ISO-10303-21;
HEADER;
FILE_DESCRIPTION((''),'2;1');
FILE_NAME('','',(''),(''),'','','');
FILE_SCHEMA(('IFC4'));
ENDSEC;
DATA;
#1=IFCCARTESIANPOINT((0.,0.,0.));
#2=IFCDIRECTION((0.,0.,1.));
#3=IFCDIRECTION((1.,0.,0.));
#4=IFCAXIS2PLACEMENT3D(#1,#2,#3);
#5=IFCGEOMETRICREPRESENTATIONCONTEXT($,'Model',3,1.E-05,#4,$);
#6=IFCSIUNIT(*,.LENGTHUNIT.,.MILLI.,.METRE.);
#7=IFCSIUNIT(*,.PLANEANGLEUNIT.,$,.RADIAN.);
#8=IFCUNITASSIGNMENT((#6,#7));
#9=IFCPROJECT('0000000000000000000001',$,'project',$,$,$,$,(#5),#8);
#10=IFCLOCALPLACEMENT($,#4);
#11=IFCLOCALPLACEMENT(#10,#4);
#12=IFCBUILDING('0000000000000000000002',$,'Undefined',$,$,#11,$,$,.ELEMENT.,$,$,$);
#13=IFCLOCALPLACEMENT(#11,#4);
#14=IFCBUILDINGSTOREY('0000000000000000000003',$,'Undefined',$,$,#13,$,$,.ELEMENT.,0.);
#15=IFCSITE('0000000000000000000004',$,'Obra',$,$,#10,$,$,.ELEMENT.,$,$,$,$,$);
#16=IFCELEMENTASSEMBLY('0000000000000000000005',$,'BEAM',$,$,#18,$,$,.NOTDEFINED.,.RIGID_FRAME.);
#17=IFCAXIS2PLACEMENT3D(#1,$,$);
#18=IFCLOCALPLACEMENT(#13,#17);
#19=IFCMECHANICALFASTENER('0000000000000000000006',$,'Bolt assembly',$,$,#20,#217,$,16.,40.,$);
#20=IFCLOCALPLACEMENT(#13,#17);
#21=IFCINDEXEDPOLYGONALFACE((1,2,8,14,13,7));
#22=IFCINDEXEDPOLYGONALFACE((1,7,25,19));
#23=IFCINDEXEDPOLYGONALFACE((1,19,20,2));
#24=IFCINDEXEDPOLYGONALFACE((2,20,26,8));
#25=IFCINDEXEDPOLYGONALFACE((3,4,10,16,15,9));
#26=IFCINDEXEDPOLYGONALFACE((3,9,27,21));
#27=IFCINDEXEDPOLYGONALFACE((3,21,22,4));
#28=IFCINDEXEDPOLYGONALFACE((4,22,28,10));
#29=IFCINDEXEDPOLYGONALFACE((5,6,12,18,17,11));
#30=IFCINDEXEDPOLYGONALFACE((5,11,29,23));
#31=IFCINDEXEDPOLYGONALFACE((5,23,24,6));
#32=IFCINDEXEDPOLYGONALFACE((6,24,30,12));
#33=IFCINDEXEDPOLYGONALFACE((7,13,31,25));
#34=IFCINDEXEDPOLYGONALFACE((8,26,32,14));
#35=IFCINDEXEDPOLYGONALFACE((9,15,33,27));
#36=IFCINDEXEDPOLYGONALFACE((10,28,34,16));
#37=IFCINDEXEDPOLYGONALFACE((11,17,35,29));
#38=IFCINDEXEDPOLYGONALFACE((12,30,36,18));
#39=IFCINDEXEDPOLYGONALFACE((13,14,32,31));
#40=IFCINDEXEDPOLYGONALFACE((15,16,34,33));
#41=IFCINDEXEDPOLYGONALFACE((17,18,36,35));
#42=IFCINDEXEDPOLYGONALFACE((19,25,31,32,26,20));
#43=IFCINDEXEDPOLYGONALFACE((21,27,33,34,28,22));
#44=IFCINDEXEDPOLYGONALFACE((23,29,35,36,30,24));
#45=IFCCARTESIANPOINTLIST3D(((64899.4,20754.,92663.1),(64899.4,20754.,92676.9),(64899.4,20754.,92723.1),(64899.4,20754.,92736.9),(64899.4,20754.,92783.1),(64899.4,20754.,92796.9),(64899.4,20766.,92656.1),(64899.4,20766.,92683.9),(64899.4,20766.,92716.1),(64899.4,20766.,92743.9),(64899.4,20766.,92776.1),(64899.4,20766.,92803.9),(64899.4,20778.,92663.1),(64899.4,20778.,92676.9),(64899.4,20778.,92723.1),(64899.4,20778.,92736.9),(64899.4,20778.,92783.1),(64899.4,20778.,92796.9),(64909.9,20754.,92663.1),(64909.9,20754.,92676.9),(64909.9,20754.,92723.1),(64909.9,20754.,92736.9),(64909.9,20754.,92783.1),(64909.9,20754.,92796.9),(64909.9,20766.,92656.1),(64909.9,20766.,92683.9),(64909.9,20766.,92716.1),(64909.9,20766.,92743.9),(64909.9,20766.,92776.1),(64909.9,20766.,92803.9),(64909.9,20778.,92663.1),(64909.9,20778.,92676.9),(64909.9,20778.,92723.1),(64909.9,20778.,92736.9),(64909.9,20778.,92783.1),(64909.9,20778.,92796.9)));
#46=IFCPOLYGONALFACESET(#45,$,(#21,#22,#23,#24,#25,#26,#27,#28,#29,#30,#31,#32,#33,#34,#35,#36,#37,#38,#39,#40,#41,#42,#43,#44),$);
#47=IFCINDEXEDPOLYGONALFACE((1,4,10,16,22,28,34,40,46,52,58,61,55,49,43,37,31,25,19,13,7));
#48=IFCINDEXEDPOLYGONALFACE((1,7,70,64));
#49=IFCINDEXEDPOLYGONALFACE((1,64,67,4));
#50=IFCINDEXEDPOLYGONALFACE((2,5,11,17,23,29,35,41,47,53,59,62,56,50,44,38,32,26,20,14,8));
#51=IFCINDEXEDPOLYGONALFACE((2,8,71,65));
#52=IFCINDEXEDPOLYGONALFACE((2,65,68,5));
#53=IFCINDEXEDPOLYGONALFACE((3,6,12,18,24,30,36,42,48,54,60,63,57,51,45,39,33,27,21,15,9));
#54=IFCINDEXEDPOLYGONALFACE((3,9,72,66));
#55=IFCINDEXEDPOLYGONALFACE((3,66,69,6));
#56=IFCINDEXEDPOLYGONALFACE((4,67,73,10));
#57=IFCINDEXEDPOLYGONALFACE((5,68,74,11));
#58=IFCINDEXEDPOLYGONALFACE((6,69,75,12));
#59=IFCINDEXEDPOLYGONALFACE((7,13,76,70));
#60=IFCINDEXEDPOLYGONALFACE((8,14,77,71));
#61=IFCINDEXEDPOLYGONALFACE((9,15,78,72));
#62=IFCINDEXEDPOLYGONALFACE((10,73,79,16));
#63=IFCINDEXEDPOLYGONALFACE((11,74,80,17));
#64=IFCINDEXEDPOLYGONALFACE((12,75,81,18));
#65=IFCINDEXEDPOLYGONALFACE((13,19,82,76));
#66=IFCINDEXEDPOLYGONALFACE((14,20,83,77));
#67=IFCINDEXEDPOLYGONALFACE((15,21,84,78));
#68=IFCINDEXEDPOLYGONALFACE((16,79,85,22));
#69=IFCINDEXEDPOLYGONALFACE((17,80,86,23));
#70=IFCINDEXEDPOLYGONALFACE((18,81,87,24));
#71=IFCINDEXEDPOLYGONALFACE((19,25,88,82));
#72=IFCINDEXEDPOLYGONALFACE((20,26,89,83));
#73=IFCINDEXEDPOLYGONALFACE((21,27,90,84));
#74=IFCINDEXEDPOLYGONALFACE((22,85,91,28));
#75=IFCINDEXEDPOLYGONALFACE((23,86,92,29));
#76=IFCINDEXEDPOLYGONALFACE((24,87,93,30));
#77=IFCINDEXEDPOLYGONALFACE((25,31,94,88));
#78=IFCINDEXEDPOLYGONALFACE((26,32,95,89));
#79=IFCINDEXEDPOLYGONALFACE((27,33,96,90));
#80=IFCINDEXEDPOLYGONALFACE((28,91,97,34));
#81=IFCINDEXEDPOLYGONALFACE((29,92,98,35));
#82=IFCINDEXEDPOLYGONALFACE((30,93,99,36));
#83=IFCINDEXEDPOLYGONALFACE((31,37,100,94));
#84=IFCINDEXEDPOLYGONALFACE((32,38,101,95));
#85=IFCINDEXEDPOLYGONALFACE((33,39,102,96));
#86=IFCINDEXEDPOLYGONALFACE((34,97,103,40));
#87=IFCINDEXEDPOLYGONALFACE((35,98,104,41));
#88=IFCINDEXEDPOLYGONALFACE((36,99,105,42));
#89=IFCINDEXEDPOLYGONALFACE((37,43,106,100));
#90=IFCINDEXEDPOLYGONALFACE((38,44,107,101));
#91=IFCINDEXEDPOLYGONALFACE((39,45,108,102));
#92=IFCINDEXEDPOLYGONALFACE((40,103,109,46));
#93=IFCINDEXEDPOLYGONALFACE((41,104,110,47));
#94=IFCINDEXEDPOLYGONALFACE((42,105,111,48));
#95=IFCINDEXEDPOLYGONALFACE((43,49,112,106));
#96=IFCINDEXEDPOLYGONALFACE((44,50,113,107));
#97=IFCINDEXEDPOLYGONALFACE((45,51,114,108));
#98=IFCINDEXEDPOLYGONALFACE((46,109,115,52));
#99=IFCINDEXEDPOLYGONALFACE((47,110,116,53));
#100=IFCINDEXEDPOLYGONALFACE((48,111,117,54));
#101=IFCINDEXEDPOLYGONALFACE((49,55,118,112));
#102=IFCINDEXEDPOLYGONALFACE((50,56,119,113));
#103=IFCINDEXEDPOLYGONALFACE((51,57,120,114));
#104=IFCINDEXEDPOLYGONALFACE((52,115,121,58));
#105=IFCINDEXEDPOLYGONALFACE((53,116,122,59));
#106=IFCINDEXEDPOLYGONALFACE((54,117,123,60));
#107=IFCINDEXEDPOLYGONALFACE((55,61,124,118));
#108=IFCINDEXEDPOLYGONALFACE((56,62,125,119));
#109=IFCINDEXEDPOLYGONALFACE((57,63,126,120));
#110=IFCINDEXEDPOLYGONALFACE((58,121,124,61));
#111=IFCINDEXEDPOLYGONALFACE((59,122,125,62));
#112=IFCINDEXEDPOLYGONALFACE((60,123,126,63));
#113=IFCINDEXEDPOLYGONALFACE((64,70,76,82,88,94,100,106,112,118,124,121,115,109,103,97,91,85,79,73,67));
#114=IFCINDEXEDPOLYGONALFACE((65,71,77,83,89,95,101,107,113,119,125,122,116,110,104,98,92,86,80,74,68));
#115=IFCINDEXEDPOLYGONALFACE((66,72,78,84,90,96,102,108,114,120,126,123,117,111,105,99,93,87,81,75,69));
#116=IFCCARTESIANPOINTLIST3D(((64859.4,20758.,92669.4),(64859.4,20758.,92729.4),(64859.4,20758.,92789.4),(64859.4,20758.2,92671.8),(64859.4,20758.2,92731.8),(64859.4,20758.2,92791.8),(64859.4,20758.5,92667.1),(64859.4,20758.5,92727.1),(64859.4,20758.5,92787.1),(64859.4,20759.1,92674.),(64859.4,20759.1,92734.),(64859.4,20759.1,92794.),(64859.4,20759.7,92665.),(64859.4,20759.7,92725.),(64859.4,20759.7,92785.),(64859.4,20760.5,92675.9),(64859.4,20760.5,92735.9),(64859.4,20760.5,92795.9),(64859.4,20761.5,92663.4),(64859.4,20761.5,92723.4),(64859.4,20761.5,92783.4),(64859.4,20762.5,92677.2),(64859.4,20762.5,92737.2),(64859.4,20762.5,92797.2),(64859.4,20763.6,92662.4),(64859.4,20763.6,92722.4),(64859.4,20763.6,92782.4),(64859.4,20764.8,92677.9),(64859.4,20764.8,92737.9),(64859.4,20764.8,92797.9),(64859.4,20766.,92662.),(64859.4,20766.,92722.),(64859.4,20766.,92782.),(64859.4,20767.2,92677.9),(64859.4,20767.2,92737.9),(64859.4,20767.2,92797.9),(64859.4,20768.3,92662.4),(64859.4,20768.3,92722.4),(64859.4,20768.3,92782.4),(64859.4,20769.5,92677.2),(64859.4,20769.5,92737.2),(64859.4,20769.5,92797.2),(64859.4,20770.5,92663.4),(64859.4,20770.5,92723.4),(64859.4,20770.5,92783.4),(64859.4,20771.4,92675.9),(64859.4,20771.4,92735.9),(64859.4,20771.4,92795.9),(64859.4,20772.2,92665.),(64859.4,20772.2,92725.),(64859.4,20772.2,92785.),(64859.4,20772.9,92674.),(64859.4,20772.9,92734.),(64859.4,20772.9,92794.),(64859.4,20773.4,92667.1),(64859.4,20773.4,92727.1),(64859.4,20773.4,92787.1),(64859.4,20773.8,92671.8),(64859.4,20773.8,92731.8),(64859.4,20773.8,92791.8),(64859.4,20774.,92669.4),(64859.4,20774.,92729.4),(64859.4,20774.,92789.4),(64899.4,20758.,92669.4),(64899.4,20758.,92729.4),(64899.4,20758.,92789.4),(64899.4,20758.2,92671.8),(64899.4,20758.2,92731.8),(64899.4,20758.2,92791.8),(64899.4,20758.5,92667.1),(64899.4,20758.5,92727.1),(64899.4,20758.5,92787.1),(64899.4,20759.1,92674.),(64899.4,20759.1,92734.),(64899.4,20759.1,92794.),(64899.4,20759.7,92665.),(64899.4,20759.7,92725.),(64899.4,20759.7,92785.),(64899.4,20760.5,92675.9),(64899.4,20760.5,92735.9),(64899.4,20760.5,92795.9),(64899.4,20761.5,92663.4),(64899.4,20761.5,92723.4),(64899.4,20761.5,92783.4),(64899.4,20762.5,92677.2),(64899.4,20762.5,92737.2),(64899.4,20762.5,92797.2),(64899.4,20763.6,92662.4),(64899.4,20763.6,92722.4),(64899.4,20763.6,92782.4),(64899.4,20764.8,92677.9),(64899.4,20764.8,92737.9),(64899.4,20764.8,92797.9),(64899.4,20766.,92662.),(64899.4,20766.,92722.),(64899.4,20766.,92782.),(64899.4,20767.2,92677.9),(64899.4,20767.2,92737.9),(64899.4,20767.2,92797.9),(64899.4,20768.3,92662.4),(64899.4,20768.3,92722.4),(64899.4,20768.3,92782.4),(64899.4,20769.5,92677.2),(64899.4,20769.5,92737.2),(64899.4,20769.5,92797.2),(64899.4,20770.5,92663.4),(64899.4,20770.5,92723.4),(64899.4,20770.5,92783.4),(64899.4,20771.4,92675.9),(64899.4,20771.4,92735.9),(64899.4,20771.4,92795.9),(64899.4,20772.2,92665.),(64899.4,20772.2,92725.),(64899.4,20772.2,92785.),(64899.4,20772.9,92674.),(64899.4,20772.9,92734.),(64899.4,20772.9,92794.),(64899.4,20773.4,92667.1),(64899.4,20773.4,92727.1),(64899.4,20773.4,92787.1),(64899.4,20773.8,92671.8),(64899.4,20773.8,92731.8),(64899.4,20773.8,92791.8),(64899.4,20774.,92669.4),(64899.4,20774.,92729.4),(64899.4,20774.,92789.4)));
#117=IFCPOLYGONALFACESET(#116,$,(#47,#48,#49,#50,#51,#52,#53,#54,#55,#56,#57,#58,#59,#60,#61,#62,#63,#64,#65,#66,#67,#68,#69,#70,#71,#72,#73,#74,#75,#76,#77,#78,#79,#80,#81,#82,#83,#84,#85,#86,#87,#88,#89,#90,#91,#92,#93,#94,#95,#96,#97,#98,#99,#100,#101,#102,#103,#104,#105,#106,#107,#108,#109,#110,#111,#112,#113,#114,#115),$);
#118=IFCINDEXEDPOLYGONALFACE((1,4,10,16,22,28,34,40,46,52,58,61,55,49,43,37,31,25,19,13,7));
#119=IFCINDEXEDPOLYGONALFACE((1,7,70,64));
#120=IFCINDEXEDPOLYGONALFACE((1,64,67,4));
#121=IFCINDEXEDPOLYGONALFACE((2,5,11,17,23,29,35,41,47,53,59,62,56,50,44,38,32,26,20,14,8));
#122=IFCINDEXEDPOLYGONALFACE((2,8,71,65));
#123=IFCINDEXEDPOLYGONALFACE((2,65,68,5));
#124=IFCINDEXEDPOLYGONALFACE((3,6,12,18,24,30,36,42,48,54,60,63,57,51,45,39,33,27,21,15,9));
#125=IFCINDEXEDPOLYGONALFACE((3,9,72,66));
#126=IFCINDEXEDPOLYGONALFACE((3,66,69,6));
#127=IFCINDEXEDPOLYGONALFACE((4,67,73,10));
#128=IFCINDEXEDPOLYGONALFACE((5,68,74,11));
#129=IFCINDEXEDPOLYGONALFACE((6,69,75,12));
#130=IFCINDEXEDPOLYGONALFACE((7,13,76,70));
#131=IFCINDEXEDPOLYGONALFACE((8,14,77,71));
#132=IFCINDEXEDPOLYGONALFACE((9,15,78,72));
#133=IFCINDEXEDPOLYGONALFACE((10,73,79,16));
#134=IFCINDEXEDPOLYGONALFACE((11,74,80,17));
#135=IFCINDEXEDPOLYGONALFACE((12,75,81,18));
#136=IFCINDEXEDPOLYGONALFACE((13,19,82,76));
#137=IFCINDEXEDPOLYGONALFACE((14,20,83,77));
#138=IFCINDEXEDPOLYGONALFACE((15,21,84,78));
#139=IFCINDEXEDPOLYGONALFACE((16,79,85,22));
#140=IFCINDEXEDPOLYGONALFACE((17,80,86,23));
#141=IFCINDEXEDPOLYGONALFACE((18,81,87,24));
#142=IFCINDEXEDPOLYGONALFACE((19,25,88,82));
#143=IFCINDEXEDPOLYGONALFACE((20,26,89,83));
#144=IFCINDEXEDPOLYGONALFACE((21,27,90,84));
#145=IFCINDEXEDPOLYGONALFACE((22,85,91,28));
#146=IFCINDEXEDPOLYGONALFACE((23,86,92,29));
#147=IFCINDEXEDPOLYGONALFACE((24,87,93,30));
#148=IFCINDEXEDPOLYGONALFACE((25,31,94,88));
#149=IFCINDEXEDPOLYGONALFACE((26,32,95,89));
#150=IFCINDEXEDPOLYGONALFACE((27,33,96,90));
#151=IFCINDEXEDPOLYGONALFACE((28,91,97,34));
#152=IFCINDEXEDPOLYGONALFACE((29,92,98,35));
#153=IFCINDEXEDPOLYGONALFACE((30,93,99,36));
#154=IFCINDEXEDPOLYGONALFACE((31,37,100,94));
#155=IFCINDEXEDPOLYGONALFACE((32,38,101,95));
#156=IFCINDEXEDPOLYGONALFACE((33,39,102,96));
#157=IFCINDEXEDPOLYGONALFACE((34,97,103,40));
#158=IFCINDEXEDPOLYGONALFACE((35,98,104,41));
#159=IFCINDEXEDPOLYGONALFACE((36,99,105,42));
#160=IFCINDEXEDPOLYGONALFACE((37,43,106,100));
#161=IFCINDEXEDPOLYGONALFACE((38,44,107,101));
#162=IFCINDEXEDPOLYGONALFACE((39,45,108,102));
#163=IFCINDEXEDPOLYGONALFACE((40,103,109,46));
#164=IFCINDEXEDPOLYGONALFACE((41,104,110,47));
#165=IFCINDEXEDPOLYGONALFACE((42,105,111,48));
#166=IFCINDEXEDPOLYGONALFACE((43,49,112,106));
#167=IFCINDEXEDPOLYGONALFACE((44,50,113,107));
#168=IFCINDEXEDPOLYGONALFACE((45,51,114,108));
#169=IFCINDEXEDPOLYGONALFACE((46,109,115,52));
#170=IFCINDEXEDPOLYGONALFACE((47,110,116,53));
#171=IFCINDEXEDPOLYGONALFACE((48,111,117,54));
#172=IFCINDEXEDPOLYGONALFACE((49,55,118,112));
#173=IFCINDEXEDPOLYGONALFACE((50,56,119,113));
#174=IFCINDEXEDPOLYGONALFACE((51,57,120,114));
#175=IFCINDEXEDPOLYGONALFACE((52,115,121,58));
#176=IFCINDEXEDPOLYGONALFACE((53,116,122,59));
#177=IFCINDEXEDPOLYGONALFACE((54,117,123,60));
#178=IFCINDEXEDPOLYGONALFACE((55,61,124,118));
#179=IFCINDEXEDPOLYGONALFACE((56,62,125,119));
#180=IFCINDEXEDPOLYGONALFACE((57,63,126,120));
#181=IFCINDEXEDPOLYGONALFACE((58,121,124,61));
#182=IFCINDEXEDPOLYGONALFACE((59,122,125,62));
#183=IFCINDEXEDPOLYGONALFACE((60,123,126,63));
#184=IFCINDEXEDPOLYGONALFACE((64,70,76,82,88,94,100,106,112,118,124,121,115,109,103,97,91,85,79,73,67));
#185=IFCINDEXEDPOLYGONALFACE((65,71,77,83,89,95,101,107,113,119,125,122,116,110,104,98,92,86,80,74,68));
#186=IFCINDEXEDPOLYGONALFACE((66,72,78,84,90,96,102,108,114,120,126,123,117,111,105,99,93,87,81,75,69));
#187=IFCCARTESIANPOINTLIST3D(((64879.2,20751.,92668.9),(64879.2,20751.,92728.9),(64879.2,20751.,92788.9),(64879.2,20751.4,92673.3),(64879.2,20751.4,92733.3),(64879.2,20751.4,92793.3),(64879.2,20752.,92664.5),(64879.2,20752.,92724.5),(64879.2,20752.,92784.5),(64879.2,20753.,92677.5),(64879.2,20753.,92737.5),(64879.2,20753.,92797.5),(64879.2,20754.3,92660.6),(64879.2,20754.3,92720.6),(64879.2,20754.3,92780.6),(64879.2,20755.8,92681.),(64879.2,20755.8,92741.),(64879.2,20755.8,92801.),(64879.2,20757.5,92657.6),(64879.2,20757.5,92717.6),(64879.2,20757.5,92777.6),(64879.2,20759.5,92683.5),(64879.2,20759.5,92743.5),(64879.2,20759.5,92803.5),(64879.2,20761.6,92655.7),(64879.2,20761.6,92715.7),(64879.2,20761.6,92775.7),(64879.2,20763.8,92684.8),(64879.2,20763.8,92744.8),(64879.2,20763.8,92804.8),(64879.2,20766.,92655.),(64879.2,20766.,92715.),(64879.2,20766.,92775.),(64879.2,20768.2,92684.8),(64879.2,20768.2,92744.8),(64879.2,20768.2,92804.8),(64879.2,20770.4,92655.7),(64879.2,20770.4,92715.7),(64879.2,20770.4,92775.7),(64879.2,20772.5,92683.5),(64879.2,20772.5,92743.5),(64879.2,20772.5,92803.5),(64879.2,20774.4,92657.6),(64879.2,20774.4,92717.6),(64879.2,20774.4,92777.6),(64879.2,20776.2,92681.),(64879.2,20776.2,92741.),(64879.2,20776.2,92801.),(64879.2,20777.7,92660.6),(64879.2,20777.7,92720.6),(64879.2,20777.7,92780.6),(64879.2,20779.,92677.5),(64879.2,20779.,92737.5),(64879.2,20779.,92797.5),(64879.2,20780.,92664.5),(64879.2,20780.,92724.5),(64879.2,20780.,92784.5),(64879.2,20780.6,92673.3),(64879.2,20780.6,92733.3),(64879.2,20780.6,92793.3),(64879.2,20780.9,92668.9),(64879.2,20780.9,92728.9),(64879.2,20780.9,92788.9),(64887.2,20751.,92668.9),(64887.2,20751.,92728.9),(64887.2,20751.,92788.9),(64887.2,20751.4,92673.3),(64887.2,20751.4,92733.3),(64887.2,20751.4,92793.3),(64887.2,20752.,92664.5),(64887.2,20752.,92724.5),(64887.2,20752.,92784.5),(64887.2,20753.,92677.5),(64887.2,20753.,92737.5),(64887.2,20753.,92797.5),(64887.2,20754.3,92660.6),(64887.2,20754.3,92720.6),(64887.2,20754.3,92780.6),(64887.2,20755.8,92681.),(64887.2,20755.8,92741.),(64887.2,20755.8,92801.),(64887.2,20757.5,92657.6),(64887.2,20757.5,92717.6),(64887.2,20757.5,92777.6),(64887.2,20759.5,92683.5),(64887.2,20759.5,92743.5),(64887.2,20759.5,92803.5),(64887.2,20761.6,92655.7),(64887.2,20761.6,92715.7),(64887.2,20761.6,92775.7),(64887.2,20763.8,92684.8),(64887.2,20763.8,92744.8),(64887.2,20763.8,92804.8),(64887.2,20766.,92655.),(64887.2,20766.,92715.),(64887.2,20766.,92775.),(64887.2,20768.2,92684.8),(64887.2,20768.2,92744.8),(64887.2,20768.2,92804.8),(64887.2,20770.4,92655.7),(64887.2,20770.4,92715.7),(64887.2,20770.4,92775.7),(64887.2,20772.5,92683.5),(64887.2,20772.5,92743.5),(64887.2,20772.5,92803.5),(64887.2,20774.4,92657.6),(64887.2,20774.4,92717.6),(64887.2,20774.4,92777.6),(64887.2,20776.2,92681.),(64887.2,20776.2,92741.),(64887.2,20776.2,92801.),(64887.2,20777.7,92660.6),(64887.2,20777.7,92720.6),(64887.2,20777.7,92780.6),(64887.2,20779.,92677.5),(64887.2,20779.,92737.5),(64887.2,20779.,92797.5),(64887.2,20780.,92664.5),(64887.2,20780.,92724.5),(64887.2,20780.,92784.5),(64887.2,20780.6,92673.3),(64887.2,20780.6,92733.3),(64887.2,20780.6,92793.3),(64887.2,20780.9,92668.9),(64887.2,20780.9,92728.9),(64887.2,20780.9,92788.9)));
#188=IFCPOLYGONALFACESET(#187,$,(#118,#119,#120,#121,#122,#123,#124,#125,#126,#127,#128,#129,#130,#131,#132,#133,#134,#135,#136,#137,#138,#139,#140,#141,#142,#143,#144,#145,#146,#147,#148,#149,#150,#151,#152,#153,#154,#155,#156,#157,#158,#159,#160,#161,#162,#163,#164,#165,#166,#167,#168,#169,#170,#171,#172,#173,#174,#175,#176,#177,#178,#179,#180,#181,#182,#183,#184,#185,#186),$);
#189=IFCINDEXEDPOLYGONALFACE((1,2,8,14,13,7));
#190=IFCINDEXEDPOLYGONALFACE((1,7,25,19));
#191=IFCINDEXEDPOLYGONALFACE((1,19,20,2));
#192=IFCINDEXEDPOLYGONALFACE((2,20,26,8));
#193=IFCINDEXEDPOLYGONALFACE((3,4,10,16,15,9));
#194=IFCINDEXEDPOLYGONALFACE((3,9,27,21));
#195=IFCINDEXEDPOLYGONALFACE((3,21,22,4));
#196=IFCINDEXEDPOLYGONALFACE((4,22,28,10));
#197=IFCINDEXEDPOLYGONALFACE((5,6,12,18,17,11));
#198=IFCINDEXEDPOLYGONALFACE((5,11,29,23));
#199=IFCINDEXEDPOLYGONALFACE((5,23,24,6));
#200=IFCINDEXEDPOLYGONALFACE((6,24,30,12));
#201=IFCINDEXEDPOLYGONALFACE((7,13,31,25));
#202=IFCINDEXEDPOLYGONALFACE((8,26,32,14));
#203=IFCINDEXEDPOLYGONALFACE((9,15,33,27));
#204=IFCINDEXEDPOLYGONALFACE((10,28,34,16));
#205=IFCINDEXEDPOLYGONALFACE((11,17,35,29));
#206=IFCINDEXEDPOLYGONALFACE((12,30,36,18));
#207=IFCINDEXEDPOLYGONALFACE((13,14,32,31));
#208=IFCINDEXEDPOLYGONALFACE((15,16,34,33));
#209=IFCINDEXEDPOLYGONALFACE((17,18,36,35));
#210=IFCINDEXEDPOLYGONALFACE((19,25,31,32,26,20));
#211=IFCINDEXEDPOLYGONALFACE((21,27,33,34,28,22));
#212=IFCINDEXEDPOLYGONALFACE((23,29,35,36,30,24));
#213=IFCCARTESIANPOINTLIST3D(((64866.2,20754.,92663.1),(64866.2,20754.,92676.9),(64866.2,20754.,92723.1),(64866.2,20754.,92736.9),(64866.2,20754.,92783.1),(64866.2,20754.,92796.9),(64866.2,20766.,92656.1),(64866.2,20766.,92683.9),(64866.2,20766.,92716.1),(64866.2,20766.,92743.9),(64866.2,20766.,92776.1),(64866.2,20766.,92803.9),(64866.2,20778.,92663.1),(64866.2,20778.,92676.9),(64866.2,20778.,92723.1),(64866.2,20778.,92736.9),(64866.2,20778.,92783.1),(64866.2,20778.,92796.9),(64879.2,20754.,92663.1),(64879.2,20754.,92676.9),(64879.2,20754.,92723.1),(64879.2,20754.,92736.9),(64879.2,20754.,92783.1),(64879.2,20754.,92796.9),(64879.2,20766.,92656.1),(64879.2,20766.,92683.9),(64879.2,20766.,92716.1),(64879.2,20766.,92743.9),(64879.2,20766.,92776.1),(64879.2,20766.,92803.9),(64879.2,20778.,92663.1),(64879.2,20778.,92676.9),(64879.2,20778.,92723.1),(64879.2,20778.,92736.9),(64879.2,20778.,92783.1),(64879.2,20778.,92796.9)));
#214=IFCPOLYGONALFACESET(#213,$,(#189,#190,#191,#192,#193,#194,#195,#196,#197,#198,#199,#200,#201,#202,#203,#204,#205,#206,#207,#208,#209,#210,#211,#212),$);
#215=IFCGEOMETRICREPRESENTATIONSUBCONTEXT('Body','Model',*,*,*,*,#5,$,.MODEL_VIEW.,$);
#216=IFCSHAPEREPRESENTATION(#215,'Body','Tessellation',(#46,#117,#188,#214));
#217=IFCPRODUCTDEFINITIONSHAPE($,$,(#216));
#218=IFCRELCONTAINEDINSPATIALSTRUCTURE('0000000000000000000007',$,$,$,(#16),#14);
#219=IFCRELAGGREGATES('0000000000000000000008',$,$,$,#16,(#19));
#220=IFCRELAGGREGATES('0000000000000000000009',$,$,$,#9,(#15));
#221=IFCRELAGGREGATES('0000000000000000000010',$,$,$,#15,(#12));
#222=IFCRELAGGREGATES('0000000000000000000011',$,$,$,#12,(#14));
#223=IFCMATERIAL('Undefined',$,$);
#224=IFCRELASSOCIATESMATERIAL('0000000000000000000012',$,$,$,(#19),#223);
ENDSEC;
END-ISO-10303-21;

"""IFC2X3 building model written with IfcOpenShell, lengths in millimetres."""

from ifc_helpers import new_model, si_unit, frame, origin_with_axes, origin_2d_with_axis, place, context, subcontext, project, spatial, polyline, circle, outline, extrude, source, transform, mapped, material, element, aggregate, save


model = new_model("IFC2X3")

# Units and contexts
model_context = context("Model", 3, precision=1e-05, world=origin_with_axes())
body_context = subcontext(model_context, "Body", "Model", "MODEL_VIEW")
ifc_project = project(units=[si_unit("LENGTHUNIT", "METRE", prefix="MILLI"), si_unit("PLANEANGLEUNIT", "RADIAN")], contexts=[model_context])

# Site, building, storey
site_placement = place(None, origin_with_axes())
site = spatial("IfcSite", under=ifc_project, at=site_placement, Name="Obra", CompositionType="ELEMENT")
building_placement = place(site_placement, origin_with_axes())
building = spatial("IfcBuilding", under=site, at=building_placement, Name="Undefined", CompositionType="ELEMENT")
storey_placement = place(building_placement, origin_with_axes())
storey = spatial("IfcBuildingStorey", under=building, at=storey_placement, Name="Undefined", CompositionType="ELEMENT", Elevation=0.0)

# Shared definitions
ifc_material_1 = material(Name="Undefined")

# Element assembly, mechanical fastener
shared_shape_1 = source(origin_with_axes(), body_context, "Body", "SweptSolid", [
    extrude(outline(polyline([(13.9, 0.0), (6.9, 12.0), (-6.9, 12.0), (-13.9, 0.0), (-6.9, -12.0), (6.9, -12.0), (13.9, 0.0)])), frame((0.0, -19.7, 0.0), z_axis=(0.0, 1.0, 0.0), x_axis=(1.0, 0.0, 0.0)), (0.0, 0.0, 1.0), 10.6),
    extrude(circle(Radius=8.0, at=origin_2d_with_axis()), frame((0.0, -9.1, 0.0), z_axis=(0.0, 1.0, 0.0), x_axis=(1.0, 0.0, 0.0)), (0.0, 0.0, 1.0), 40.0),
    extrude(circle(Radius=15.0, at=origin_2d_with_axis()), frame((0.0, 3.1, 0.0), z_axis=(0.0, 1.0, 0.0), x_axis=(1.0, 0.0, 0.0)), (0.0, 0.0, 1.0), 8.0),
    extrude(outline(polyline([(13.9, 0.0), (6.9, 12.0), (-6.9, 12.0), (-13.9, 0.0), (-6.9, -12.0), (6.9, -12.0), (13.9, 0.0)])), frame((0.0, 11.1, 0.0), z_axis=(0.0, 1.0, 0.0), x_axis=(1.0, 0.0, 0.0)), (0.0, 0.0, 1.0), 13.0),
])
assembly_1_placement = place(storey_placement, origin_with_axes())
assembly_1 = element("IfcElementAssembly", 1, at=assembly_1_placement, inside=storey, Name="BEAM", AssemblyPlace="NOTDEFINED", PredefinedType="RIGID_FRAME")
mechanical_fastener_1_placement = place(assembly_1_placement, frame((64890.3, 20716.0, 92850.0), z_axis=(-0.000002, 1.0, 0.0), x_axis=(0.0, 0.0, -1.0)))
mechanical_fastener_1 = element("IfcMechanicalFastener", 2, at=mechanical_fastener_1_placement, material=ifc_material_1, Name="Bolt assembly", NominalDiameter=16.0, NominalLength=40.0, context=body_context, shape_type="MappedRepresentation", body=[
    mapped(shared_shape_1, transform((60.0, 0.0, 50.0))),
    mapped(shared_shape_1, transform((120.0, 0.0, 50.0))),
    mapped(shared_shape_1, transform((180.0, 0.0, 50.0))),
])
aggregate(assembly_1, [mechanical_fastener_1])

save(model, "model.ifc")
